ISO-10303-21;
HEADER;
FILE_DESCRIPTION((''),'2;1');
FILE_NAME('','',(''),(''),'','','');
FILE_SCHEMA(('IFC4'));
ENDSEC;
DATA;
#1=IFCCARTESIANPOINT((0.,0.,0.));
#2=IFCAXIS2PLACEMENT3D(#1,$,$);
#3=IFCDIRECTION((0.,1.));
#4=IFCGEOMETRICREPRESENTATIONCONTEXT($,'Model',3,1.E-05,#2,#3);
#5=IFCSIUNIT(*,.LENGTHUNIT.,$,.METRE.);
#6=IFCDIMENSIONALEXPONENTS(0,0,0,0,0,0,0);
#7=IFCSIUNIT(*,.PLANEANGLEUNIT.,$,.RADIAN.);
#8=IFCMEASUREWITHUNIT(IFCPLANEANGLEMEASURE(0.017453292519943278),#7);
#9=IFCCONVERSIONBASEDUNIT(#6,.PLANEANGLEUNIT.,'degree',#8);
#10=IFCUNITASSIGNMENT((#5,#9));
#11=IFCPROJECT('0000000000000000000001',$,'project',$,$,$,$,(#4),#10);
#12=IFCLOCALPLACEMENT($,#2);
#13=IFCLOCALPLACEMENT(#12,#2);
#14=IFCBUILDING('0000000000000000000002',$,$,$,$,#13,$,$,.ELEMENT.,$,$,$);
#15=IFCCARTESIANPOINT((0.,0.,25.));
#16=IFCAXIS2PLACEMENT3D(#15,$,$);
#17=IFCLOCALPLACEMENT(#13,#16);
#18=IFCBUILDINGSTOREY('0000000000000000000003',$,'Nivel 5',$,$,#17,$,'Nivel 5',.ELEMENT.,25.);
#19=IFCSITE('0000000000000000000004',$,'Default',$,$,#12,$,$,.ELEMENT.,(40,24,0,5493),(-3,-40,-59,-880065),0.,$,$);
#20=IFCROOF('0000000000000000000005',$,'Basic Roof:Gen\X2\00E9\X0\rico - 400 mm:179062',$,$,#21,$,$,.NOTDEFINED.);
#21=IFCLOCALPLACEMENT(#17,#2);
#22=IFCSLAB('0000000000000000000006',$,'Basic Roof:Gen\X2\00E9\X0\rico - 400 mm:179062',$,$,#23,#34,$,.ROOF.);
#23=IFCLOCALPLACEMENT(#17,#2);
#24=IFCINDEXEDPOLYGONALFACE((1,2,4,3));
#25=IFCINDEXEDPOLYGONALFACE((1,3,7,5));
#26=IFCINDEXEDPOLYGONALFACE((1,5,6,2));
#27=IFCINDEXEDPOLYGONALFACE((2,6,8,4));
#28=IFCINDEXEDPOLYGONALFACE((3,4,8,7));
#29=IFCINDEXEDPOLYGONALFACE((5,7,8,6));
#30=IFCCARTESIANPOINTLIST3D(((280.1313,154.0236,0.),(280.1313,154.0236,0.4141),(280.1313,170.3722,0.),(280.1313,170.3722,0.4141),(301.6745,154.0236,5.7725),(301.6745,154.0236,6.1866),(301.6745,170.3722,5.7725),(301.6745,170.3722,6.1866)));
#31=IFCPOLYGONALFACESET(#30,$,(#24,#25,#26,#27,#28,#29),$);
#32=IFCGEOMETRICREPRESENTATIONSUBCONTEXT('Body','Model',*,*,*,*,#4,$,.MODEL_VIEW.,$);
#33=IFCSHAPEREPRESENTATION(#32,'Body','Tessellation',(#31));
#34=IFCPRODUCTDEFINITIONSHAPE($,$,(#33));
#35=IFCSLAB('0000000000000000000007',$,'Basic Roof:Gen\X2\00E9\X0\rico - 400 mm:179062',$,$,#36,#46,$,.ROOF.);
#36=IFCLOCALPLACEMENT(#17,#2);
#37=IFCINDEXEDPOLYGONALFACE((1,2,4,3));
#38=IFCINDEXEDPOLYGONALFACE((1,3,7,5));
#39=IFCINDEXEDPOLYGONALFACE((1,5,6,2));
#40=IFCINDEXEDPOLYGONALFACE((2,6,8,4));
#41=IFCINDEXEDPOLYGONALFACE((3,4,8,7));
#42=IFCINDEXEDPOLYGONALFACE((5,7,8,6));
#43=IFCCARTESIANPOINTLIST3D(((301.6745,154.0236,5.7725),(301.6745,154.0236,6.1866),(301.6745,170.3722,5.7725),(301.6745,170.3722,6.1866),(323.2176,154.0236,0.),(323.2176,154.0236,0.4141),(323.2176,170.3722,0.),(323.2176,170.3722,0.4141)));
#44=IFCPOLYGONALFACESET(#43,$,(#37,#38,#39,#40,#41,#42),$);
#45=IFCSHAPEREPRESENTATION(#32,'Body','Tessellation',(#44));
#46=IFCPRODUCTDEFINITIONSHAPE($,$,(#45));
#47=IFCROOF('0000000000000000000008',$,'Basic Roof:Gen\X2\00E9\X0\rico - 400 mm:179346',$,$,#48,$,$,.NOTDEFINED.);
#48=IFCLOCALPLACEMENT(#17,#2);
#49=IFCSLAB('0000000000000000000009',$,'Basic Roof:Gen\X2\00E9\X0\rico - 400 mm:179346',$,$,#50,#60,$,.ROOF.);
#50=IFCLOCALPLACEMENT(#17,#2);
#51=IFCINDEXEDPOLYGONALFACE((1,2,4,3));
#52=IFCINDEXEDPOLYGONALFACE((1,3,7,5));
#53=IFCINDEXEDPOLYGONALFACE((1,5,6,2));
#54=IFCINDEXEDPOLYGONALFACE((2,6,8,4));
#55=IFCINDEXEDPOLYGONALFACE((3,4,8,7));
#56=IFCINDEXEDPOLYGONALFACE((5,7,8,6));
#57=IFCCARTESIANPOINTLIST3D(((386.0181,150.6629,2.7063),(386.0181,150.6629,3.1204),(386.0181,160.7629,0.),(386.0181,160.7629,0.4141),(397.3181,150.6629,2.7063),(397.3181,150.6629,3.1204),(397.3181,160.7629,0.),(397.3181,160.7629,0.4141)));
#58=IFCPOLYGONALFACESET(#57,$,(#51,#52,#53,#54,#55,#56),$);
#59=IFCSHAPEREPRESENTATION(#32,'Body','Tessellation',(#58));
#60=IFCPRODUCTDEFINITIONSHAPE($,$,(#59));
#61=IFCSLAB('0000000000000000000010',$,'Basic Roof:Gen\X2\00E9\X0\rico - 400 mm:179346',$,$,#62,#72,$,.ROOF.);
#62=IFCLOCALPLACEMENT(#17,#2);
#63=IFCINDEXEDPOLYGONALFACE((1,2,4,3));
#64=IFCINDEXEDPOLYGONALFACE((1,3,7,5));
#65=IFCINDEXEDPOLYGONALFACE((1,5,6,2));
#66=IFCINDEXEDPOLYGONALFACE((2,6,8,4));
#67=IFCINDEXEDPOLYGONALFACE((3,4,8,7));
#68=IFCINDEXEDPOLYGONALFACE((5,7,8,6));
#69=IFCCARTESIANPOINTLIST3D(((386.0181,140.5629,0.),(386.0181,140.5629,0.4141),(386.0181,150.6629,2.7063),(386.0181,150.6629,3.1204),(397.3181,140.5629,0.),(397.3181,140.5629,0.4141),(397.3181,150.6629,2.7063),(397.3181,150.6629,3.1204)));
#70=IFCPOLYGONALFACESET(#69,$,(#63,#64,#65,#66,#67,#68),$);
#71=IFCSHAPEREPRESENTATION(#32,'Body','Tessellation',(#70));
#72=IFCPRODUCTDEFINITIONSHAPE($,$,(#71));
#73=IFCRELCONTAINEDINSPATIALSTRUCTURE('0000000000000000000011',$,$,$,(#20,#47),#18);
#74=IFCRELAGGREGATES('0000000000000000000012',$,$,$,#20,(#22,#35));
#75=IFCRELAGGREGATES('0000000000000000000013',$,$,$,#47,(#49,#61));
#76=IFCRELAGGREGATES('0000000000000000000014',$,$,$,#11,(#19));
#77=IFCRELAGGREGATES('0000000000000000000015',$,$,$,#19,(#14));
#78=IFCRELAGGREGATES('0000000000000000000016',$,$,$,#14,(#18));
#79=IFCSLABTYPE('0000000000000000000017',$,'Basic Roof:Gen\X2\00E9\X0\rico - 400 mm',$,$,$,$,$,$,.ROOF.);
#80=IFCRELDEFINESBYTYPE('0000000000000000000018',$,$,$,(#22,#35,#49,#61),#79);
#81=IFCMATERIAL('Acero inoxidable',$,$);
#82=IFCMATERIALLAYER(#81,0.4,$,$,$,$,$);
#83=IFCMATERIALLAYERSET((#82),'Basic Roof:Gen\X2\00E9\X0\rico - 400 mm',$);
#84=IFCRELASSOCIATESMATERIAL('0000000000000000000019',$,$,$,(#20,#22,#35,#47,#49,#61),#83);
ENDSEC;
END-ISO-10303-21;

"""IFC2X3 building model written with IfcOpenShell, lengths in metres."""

from ifc_helpers import new_model, entity, si_unit, converted_unit, direction, frame, frame_2d, origin, place, context, subcontext, project, spatial, rectangle, extrude, material, layer, layer_set, type_object, element, aggregate, save


model = new_model("IFC2X3")

# Units and contexts
model_context = context("Model", 3, precision=1e-05, world=origin(), true_north=direction((0.0, 1.0)))
body_context = subcontext(model_context, "Body", "Model", "MODEL_VIEW")
ifc_project = project(units=[si_unit("LENGTHUNIT", "METRE"), converted_unit("PLANEANGLEUNIT", "degree", entity("IfcPlaneAngleMeasure", 0.017453292519943278), si_unit("PLANEANGLEUNIT", "RADIAN"), dimensions=[0, 0, 0, 0, 0, 0, 0])], contexts=[model_context])

# Site, building, storey
site_placement = place(None, origin())
site = spatial("IfcSite", under=ifc_project, at=site_placement, Name="Default", CompositionType="ELEMENT", RefLatitude=(40, 24, 0, 5493), RefLongitude=(-3, -40, -59, -880065), RefElevation=0.0)
building_placement = place(site_placement, origin())
building = spatial("IfcBuilding", under=site, at=building_placement, CompositionType="ELEMENT")
storey_placement = place(building_placement, frame((0.0, 0.0, 25.0)))
storey = spatial("IfcBuildingStorey", under=building, at=storey_placement, Name="Nivel 5", LongName="Nivel 5", CompositionType="ELEMENT", Elevation=25.0)

# Roofs, slabs
ifc_material_1 = material(Name="Acero inoxidable")
ifc_layer = layer(ifc_material_1, 0.4)
ifc_layer_set = layer_set([ifc_layer], Name="Basic Roof:Genérico - 400 mm")
roof_1_placement = place(storey_placement, frame((280.1313, 154.0236, 0.0)))
roof_1 = element("IfcRoof", 1, at=roof_1_placement, inside=storey, material=ifc_layer_set, Name="Basic Roof:Genérico - 400 mm:179062", ShapeType="NOTDEFINED")
slab_type = type_object("IfcSlabType", Name="Basic Roof:Genérico - 400 mm", PredefinedType="ROOF")
slab_1_placement = place(roof_1_placement, origin())
slab_1 = element("IfcSlab", 2, at=slab_1_placement, type_object=slab_type, material=ifc_layer_set, Name="Basic Roof:Genérico - 400 mm:179062", PredefinedType="ROOF", context=body_context, shape_type="SweptSolid", body=[
    extrude(rectangle(XDim=16.3486, YDim=22.3031, at=frame_2d((0.0, 0.0), x_axis=(0.0, 1.0))), frame((10.7716, 8.1743, 2.8862), z_axis=(-0.258819, 0.0, 0.965926), x_axis=(0.965926, 0.0, 0.258819)), (0.258819, 0.0, 0.965926), 0.4141),
])
slab_2_placement = place(roof_1_placement, origin())
slab_2 = element("IfcSlab", 3, at=slab_2_placement, type_object=slab_type, material=ifc_layer_set, Name="Basic Roof:Genérico - 400 mm:179062", PredefinedType="ROOF", context=body_context, shape_type="SweptSolid", body=[
    extrude(rectangle(XDim=22.3031, YDim=16.3486, at=frame_2d((0.0, 0.0), x_axis=(1.0, 0.0))), frame((32.3147, 8.1743, 2.8862), z_axis=(0.258819, 0.0, 0.965926), x_axis=(0.965926, 0.0, -0.258819)), (-0.258819, 0.0, 0.965926), 0.4141),
])
aggregate(roof_1, [slab_1, slab_2])
roof_2_placement = place(storey_placement, frame((386.0181, 140.5629, 0.0)))
roof_2 = element("IfcRoof", 4, at=roof_2_placement, inside=storey, material=ifc_layer_set, Name="Basic Roof:Genérico - 400 mm:179346", ShapeType="NOTDEFINED")
slab_3_placement = place(roof_2_placement, origin())
slab_3 = element("IfcSlab", 5, at=slab_3_placement, type_object=slab_type, material=ifc_layer_set, Name="Basic Roof:Genérico - 400 mm:179346", PredefinedType="ROOF", context=body_context, shape_type="SweptSolid", body=[
    extrude(rectangle(XDim=11.3, YDim=10.4563, at=frame_2d((0.0, 0.0), x_axis=(1.0, 0.0))), frame((5.65, 15.15, 1.3531), z_axis=(0.0, 0.258819, 0.965926), x_axis=(1.0, 0.0, 0.0)), (0.0, -0.258819, 0.965926), 0.4141),
])
slab_4_placement = place(roof_2_placement, origin())
slab_4 = element("IfcSlab", 6, at=slab_4_placement, type_object=slab_type, material=ifc_layer_set, Name="Basic Roof:Genérico - 400 mm:179346", PredefinedType="ROOF", context=body_context, shape_type="SweptSolid", body=[
    extrude(rectangle(XDim=10.4563, YDim=11.3, at=frame_2d((0.0, 0.0), x_axis=(0.0, 1.0))), frame((5.65, 5.05, 1.3531), z_axis=(0.0, -0.258819, 0.965926), x_axis=(1.0, 0.0, 0.0)), (0.0, 0.258819, 0.965926), 0.4141),
])
aggregate(roof_2, [slab_3, slab_4])

save(model, "model.ifc")
